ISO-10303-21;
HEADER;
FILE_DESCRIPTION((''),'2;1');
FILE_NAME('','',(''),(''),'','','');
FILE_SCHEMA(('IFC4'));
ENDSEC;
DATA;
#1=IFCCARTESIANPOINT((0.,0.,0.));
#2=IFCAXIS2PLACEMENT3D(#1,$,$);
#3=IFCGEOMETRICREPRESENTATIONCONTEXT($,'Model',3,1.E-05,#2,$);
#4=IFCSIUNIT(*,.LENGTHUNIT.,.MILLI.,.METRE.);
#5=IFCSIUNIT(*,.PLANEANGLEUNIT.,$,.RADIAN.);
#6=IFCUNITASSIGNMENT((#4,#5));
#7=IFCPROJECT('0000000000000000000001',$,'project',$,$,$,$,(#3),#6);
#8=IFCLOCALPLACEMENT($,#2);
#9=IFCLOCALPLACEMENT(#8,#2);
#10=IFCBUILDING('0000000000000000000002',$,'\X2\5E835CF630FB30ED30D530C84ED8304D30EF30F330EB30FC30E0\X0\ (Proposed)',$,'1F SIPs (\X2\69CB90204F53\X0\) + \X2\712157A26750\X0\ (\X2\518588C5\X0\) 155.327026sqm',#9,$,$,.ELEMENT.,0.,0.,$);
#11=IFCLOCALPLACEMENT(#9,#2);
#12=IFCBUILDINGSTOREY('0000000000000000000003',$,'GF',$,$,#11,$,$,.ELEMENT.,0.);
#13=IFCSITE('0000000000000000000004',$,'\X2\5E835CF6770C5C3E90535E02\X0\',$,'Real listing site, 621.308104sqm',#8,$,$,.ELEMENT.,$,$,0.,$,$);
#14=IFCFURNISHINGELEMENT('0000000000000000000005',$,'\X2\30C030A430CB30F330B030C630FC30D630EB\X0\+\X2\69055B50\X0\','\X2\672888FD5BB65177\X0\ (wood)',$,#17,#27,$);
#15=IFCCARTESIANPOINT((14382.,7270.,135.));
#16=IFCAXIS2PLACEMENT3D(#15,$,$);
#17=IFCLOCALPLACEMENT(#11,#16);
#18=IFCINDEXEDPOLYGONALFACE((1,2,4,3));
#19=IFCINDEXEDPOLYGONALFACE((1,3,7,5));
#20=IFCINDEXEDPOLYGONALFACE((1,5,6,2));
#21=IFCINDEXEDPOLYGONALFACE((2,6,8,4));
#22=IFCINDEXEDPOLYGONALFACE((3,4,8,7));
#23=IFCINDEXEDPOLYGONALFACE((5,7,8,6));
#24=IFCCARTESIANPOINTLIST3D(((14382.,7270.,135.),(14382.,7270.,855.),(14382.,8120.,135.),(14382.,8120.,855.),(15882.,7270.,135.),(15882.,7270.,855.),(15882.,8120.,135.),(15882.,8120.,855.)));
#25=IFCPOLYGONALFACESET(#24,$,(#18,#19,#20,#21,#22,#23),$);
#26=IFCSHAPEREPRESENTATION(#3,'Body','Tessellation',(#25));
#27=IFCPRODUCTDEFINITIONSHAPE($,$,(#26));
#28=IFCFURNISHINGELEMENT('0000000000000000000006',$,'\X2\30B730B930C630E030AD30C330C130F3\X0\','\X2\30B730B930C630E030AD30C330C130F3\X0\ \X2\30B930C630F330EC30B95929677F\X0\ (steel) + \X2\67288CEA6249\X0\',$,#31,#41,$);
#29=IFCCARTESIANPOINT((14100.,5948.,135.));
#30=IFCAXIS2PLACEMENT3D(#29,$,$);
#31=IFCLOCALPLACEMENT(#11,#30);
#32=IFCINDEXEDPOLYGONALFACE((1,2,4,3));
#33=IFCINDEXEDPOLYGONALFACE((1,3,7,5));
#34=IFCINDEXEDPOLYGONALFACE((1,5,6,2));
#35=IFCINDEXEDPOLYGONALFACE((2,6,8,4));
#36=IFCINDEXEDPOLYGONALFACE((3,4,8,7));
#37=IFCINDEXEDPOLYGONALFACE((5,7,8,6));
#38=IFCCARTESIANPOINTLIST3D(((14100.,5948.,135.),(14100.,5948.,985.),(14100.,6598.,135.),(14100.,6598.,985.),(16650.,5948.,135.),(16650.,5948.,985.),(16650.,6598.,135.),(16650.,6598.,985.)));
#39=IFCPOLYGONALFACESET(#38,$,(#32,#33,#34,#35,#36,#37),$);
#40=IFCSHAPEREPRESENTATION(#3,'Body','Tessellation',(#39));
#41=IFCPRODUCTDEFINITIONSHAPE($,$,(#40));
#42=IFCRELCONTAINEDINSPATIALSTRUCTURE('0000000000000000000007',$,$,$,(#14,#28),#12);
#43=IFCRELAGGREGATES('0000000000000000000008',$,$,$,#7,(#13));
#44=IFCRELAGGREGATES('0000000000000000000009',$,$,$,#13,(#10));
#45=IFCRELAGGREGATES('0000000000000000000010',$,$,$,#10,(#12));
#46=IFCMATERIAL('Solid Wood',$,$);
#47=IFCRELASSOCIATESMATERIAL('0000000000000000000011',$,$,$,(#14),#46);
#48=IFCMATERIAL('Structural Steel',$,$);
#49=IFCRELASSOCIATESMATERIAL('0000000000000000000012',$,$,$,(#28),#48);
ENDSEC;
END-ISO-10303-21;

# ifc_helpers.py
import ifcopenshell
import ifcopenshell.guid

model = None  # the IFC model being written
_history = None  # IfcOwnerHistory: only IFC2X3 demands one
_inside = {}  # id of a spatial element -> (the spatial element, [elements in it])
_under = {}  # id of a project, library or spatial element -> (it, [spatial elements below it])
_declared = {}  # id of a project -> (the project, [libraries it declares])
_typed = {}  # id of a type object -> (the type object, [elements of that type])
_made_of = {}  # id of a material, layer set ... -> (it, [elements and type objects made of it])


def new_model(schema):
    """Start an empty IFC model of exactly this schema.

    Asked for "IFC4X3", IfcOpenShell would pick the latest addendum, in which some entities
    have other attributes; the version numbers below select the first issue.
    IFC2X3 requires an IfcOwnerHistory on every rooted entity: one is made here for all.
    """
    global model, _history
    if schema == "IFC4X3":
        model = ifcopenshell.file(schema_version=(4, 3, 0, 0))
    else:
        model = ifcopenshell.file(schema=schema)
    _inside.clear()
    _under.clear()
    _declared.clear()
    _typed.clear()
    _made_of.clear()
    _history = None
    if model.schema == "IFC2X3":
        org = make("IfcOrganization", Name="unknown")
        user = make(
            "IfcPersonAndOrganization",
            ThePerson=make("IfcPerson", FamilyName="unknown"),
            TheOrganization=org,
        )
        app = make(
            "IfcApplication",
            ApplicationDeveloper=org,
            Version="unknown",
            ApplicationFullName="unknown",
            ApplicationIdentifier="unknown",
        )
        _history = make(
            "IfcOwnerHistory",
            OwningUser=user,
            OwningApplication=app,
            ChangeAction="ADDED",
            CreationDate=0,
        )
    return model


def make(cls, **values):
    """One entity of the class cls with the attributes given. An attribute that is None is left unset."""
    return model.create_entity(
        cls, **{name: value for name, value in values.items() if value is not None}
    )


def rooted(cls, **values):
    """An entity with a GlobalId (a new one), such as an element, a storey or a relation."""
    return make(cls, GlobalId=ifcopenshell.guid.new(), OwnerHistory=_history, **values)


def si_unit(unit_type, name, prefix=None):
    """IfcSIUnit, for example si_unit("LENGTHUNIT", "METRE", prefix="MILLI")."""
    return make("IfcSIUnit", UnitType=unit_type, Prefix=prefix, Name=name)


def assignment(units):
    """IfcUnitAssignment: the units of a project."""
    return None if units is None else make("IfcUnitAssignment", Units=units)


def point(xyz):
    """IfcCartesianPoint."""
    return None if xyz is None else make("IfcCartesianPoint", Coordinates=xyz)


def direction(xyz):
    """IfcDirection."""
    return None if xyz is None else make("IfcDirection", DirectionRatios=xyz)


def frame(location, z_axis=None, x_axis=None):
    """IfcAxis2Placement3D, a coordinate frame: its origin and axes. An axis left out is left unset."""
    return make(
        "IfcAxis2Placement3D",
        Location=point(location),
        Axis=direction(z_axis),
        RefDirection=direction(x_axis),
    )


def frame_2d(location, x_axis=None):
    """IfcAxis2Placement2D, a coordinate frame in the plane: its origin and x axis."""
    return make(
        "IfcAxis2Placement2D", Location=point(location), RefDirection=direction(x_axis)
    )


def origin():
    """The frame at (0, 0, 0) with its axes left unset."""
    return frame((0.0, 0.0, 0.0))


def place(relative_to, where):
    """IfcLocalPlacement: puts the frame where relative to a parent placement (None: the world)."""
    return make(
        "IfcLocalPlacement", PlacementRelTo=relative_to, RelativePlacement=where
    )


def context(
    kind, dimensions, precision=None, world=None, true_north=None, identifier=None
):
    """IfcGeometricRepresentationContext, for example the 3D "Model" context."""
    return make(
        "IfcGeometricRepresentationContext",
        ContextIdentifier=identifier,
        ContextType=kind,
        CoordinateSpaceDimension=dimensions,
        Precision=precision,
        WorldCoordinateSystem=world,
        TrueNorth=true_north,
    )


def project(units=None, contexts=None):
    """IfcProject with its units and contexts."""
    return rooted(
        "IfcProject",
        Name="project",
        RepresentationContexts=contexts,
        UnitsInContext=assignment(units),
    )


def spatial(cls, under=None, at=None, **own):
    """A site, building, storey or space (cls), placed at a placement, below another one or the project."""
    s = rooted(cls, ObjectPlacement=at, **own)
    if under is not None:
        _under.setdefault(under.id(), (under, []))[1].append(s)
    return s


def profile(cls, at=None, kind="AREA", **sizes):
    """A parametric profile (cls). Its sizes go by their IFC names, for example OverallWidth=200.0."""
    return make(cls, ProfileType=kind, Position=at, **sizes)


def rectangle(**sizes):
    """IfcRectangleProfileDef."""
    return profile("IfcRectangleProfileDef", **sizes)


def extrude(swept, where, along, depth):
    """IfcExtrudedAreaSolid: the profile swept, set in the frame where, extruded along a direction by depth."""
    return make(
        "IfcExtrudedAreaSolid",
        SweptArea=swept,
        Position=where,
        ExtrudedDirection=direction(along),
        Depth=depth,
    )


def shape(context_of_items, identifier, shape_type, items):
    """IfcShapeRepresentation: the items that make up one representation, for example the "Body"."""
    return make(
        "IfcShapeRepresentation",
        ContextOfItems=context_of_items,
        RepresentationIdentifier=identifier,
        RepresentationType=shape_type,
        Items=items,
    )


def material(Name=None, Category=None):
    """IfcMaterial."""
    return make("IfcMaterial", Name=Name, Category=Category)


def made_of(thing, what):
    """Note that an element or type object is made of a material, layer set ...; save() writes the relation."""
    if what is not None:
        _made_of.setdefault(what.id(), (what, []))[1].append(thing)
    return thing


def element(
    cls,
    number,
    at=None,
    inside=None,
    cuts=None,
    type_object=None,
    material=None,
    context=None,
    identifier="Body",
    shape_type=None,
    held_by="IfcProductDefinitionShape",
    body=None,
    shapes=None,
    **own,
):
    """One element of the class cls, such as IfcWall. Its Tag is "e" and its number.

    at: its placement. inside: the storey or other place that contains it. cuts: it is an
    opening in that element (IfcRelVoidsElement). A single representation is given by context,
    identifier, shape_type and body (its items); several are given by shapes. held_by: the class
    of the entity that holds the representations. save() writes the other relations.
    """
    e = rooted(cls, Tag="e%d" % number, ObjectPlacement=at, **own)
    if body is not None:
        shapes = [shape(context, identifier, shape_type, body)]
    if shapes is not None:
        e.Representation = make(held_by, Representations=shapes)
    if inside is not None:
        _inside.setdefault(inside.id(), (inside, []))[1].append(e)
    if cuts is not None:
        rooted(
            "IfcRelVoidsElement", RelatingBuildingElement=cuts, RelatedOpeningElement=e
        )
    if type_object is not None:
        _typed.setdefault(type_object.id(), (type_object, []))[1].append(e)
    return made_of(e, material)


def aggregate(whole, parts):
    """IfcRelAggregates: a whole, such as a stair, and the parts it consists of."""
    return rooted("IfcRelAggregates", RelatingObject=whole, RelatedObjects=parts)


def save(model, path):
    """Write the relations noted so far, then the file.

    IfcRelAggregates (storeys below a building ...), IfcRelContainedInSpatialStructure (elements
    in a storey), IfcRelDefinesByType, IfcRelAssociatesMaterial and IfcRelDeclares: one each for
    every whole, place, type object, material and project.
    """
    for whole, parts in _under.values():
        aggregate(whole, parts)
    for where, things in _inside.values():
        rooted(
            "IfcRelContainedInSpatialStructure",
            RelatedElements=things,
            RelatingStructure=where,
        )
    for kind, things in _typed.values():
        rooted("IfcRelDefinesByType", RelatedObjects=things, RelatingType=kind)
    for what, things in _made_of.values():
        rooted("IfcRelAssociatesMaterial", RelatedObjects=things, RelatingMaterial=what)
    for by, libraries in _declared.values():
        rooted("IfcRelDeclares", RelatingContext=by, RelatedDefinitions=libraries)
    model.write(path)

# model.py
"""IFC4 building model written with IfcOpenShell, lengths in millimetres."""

from ifc_helpers import new_model, si_unit, frame, frame_2d, origin, place, context, project, spatial, rectangle, extrude, material, element, save


model = new_model("IFC4")

# Units and contexts
model_context = context("Model", 3, precision=1e-05, world=origin())
ifc_project = project(units=[si_unit("LENGTHUNIT", "METRE", prefix="MILLI"), si_unit("PLANEANGLEUNIT", "RADIAN")], contexts=[model_context])

# Site, building, storey
site_placement = place(None, origin())
site = spatial("IfcSite", under=ifc_project, at=site_placement, Name="広島県尾道市", ObjectType="Real listing site, 621.308104sqm", CompositionType="ELEMENT", RefElevation=0.0)
building_placement = place(site_placement, origin())
building = spatial("IfcBuilding", under=site, at=building_placement, Name="広島・ロフト付きワンルーム (Proposed)", ObjectType="1F SIPs (構造体) + 無垢材 (内装) 155.327026sqm", CompositionType="ELEMENT", ElevationOfRefHeight=0.0, ElevationOfTerrain=0.0)
storey_placement = place(building_placement, origin())
storey = spatial("IfcBuildingStorey", under=building, at=storey_placement, Name="GF", CompositionType="ELEMENT", Elevation=0.0)

# Shared definitions
ifc_material_1 = material(Name="Solid Wood")

# Furnishing elements
furnishing_1_placement = place(storey_placement, frame((14382.0, 7270.0, 135.0)))
element("IfcFurnishingElement", 1, at=furnishing_1_placement, inside=storey, material=ifc_material_1, Name="ダイニングテーブル+椅子", Description="木製家具 (wood)", context=model_context, shape_type="SweptSolid", body=[
    extrude(rectangle(XDim=1500.0, YDim=850.0, at=frame_2d((750.0, 425.0))), frame((14382.0, 7270.0, 135.0)), (0.0, 0.0, 1.0), 720.0),
])
ifc_material_2 = material(Name="Structural Steel")
furnishing_2_placement = place(storey_placement, frame((14100.0, 5948.0, 135.0)))
element("IfcFurnishingElement", 2, at=furnishing_2_placement, inside=storey, material=ifc_material_2, Name="システムキッチン", Description="システムキッチン ステンレス天板 (steel) + 木質扉", context=model_context, shape_type="SweptSolid", body=[
    extrude(rectangle(XDim=2550.0, YDim=650.0, at=frame_2d((1275.0, 325.0))), frame((14100.0, 5948.0, 135.0)), (0.0, 0.0, 1.0), 850.0),
])

save(model, "model.ifc")
